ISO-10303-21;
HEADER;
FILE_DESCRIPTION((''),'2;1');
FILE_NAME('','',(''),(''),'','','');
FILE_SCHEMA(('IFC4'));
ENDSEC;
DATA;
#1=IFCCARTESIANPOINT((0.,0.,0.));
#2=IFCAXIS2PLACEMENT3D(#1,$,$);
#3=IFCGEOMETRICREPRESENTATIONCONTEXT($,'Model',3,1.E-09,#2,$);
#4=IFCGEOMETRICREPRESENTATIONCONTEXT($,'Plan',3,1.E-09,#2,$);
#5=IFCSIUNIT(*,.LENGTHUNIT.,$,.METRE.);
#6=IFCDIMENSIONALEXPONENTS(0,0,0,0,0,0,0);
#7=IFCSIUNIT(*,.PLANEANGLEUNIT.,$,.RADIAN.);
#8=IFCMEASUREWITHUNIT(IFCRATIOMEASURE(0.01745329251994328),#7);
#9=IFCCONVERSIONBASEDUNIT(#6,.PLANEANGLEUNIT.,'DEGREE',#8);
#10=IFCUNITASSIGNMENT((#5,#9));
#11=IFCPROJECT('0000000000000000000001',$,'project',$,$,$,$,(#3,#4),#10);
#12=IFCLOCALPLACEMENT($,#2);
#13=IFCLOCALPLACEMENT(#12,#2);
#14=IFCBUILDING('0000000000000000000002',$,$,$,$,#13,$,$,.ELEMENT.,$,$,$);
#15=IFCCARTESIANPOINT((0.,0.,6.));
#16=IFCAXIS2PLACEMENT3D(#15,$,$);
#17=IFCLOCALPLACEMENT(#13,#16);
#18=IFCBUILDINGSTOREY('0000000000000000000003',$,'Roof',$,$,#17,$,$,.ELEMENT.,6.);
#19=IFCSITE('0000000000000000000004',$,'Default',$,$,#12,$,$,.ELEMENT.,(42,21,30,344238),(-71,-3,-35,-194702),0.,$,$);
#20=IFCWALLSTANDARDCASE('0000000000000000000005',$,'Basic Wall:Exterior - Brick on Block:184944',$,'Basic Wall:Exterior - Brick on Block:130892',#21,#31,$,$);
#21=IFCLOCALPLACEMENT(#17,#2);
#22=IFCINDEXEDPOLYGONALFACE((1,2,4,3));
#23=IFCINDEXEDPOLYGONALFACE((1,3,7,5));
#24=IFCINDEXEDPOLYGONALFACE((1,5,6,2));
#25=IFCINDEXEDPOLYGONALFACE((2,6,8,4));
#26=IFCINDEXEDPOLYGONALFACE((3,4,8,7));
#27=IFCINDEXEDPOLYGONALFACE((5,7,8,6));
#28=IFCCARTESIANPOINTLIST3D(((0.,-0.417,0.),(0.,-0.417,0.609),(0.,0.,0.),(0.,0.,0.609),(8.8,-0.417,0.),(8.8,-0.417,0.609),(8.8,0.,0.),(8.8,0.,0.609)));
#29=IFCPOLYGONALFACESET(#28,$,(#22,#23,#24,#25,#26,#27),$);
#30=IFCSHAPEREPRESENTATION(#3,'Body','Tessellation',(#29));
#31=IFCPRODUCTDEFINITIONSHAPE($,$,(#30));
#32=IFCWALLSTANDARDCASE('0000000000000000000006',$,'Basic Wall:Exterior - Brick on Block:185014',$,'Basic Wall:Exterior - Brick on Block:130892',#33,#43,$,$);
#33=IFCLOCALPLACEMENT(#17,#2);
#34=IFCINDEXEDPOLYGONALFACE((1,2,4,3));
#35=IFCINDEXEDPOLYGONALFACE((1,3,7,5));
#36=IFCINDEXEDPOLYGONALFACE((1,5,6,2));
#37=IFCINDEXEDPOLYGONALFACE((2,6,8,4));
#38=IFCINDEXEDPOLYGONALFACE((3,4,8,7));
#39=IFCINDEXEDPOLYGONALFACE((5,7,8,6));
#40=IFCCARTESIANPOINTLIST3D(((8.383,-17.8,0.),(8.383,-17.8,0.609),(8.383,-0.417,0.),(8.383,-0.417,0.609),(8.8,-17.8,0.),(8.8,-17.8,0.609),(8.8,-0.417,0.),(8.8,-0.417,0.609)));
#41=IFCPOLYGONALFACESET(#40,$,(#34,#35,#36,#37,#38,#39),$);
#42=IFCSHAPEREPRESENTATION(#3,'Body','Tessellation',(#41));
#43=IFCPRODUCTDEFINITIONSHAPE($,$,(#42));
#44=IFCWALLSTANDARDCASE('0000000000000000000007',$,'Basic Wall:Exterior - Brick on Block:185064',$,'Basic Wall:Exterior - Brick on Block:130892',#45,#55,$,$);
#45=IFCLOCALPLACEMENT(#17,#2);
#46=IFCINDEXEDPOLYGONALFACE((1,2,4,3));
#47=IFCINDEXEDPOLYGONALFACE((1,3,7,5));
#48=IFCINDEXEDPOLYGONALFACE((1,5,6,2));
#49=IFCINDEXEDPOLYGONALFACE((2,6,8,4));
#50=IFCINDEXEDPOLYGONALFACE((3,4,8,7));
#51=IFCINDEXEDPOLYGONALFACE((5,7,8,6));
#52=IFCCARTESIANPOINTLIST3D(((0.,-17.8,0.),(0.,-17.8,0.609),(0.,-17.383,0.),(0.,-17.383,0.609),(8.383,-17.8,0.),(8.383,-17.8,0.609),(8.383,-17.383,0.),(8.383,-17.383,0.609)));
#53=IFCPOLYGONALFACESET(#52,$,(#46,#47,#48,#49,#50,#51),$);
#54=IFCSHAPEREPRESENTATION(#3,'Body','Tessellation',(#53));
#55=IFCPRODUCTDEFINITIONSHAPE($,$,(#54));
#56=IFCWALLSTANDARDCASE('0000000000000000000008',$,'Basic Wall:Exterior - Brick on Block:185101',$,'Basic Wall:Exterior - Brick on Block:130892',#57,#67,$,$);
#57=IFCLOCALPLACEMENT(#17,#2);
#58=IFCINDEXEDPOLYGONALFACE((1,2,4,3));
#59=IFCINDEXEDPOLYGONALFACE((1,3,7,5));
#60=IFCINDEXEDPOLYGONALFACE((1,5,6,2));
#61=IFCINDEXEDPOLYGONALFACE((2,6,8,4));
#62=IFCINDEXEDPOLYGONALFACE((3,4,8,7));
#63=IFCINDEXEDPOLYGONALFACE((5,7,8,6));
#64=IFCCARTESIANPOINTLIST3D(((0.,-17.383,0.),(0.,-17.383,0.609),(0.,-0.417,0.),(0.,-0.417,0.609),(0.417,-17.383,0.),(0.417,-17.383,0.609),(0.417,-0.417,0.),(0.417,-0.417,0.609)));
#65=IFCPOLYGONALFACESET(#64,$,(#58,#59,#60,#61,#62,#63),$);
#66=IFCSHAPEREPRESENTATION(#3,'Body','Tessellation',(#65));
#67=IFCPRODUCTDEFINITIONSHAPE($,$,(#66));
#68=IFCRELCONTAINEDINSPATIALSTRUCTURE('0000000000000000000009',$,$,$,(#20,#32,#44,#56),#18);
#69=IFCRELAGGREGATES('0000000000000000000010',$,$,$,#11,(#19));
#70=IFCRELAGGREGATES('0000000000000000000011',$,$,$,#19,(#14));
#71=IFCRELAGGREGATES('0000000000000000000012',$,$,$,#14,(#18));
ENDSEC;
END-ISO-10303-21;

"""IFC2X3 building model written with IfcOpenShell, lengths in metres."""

from ifc_helpers import new_model, entity, si_unit, converted_unit, frame, frame_2d, origin, place, context, project, spatial, rectangle, extrude, element, save


model = new_model("IFC2X3")

# Units and contexts
model_context = context("Model", 3, precision=1e-09, world=origin())
plan_context = context("Plan", 3, precision=1e-09, world=origin())
ifc_project = project(units=[si_unit("LENGTHUNIT", "METRE"), converted_unit("PLANEANGLEUNIT", "DEGREE", entity("IfcRatioMeasure", 0.01745329251994328), si_unit("PLANEANGLEUNIT", "RADIAN"), dimensions=[0, 0, 0, 0, 0, 0, 0])], contexts=[model_context, plan_context])

# Site, building, storey
site_placement = place(None, origin())
site = spatial("IfcSite", under=ifc_project, at=site_placement, Name="Default", CompositionType="ELEMENT", RefLatitude=(42, 21, 30, 344238), RefLongitude=(-71, -3, -35, -194702), RefElevation=0.0)
building_placement = place(site_placement, origin())
building = spatial("IfcBuilding", under=site, at=building_placement, CompositionType="ELEMENT")
storey_placement = place(building_placement, frame((0.0, 0.0, 6.0)))
storey = spatial("IfcBuildingStorey", under=building, at=storey_placement, Name="Roof", CompositionType="ELEMENT", Elevation=6.0)

# Walls
wall_1_placement = place(storey_placement, frame((0.0, -0.2085, 0.0)))
element("IfcWallStandardCase", 1, at=wall_1_placement, inside=storey, Name="Basic Wall:Exterior - Brick on Block:184944", ObjectType="Basic Wall:Exterior - Brick on Block:130892", context=model_context, shape_type="SweptSolid", body=[
    extrude(rectangle(XDim=8.8, YDim=0.417, at=frame_2d((4.4, 0.0), x_axis=(-1.0, 0.0))), origin(), (0.0, 0.0, 1.0), 0.609),
])
wall_2_placement = place(storey_placement, frame((8.5915, -0.417, 0.0), z_axis=(0.0, 0.0, 1.0), x_axis=(0.0, -1.0, 0.0)))
element("IfcWallStandardCase", 2, at=wall_2_placement, inside=storey, Name="Basic Wall:Exterior - Brick on Block:185014", ObjectType="Basic Wall:Exterior - Brick on Block:130892", context=model_context, shape_type="SweptSolid", body=[
    extrude(rectangle(XDim=17.383, YDim=0.417, at=frame_2d((8.6915, 0.0), x_axis=(-1.0, 0.0))), origin(), (0.0, 0.0, 1.0), 0.609),
])
wall_3_placement = place(storey_placement, frame((8.383, -17.5915, 0.0), z_axis=(0.0, 0.0, 1.0), x_axis=(-1.0, 0.0, 0.0)))
element("IfcWallStandardCase", 3, at=wall_3_placement, inside=storey, Name="Basic Wall:Exterior - Brick on Block:185064", ObjectType="Basic Wall:Exterior - Brick on Block:130892", context=model_context, shape_type="SweptSolid", body=[
    extrude(rectangle(XDim=8.383, YDim=0.417, at=frame_2d((4.1915, 0.0), x_axis=(-1.0, 0.0))), origin(), (0.0, 0.0, 1.0), 0.609),
])
wall_4_placement = place(storey_placement, frame((0.2085, -17.383, 0.0), z_axis=(0.0, 0.0, 1.0), x_axis=(0.0, 1.0, 0.0)))
element("IfcWallStandardCase", 4, at=wall_4_placement, inside=storey, Name="Basic Wall:Exterior - Brick on Block:185101", ObjectType="Basic Wall:Exterior - Brick on Block:130892", context=model_context, shape_type="SweptSolid", body=[
    extrude(rectangle(XDim=16.966, YDim=0.417, at=frame_2d((8.483, 0.0), x_axis=(-1.0, 0.0))), origin(), (0.0, 0.0, 1.0), 0.609),
])

save(model, "model.ifc")
